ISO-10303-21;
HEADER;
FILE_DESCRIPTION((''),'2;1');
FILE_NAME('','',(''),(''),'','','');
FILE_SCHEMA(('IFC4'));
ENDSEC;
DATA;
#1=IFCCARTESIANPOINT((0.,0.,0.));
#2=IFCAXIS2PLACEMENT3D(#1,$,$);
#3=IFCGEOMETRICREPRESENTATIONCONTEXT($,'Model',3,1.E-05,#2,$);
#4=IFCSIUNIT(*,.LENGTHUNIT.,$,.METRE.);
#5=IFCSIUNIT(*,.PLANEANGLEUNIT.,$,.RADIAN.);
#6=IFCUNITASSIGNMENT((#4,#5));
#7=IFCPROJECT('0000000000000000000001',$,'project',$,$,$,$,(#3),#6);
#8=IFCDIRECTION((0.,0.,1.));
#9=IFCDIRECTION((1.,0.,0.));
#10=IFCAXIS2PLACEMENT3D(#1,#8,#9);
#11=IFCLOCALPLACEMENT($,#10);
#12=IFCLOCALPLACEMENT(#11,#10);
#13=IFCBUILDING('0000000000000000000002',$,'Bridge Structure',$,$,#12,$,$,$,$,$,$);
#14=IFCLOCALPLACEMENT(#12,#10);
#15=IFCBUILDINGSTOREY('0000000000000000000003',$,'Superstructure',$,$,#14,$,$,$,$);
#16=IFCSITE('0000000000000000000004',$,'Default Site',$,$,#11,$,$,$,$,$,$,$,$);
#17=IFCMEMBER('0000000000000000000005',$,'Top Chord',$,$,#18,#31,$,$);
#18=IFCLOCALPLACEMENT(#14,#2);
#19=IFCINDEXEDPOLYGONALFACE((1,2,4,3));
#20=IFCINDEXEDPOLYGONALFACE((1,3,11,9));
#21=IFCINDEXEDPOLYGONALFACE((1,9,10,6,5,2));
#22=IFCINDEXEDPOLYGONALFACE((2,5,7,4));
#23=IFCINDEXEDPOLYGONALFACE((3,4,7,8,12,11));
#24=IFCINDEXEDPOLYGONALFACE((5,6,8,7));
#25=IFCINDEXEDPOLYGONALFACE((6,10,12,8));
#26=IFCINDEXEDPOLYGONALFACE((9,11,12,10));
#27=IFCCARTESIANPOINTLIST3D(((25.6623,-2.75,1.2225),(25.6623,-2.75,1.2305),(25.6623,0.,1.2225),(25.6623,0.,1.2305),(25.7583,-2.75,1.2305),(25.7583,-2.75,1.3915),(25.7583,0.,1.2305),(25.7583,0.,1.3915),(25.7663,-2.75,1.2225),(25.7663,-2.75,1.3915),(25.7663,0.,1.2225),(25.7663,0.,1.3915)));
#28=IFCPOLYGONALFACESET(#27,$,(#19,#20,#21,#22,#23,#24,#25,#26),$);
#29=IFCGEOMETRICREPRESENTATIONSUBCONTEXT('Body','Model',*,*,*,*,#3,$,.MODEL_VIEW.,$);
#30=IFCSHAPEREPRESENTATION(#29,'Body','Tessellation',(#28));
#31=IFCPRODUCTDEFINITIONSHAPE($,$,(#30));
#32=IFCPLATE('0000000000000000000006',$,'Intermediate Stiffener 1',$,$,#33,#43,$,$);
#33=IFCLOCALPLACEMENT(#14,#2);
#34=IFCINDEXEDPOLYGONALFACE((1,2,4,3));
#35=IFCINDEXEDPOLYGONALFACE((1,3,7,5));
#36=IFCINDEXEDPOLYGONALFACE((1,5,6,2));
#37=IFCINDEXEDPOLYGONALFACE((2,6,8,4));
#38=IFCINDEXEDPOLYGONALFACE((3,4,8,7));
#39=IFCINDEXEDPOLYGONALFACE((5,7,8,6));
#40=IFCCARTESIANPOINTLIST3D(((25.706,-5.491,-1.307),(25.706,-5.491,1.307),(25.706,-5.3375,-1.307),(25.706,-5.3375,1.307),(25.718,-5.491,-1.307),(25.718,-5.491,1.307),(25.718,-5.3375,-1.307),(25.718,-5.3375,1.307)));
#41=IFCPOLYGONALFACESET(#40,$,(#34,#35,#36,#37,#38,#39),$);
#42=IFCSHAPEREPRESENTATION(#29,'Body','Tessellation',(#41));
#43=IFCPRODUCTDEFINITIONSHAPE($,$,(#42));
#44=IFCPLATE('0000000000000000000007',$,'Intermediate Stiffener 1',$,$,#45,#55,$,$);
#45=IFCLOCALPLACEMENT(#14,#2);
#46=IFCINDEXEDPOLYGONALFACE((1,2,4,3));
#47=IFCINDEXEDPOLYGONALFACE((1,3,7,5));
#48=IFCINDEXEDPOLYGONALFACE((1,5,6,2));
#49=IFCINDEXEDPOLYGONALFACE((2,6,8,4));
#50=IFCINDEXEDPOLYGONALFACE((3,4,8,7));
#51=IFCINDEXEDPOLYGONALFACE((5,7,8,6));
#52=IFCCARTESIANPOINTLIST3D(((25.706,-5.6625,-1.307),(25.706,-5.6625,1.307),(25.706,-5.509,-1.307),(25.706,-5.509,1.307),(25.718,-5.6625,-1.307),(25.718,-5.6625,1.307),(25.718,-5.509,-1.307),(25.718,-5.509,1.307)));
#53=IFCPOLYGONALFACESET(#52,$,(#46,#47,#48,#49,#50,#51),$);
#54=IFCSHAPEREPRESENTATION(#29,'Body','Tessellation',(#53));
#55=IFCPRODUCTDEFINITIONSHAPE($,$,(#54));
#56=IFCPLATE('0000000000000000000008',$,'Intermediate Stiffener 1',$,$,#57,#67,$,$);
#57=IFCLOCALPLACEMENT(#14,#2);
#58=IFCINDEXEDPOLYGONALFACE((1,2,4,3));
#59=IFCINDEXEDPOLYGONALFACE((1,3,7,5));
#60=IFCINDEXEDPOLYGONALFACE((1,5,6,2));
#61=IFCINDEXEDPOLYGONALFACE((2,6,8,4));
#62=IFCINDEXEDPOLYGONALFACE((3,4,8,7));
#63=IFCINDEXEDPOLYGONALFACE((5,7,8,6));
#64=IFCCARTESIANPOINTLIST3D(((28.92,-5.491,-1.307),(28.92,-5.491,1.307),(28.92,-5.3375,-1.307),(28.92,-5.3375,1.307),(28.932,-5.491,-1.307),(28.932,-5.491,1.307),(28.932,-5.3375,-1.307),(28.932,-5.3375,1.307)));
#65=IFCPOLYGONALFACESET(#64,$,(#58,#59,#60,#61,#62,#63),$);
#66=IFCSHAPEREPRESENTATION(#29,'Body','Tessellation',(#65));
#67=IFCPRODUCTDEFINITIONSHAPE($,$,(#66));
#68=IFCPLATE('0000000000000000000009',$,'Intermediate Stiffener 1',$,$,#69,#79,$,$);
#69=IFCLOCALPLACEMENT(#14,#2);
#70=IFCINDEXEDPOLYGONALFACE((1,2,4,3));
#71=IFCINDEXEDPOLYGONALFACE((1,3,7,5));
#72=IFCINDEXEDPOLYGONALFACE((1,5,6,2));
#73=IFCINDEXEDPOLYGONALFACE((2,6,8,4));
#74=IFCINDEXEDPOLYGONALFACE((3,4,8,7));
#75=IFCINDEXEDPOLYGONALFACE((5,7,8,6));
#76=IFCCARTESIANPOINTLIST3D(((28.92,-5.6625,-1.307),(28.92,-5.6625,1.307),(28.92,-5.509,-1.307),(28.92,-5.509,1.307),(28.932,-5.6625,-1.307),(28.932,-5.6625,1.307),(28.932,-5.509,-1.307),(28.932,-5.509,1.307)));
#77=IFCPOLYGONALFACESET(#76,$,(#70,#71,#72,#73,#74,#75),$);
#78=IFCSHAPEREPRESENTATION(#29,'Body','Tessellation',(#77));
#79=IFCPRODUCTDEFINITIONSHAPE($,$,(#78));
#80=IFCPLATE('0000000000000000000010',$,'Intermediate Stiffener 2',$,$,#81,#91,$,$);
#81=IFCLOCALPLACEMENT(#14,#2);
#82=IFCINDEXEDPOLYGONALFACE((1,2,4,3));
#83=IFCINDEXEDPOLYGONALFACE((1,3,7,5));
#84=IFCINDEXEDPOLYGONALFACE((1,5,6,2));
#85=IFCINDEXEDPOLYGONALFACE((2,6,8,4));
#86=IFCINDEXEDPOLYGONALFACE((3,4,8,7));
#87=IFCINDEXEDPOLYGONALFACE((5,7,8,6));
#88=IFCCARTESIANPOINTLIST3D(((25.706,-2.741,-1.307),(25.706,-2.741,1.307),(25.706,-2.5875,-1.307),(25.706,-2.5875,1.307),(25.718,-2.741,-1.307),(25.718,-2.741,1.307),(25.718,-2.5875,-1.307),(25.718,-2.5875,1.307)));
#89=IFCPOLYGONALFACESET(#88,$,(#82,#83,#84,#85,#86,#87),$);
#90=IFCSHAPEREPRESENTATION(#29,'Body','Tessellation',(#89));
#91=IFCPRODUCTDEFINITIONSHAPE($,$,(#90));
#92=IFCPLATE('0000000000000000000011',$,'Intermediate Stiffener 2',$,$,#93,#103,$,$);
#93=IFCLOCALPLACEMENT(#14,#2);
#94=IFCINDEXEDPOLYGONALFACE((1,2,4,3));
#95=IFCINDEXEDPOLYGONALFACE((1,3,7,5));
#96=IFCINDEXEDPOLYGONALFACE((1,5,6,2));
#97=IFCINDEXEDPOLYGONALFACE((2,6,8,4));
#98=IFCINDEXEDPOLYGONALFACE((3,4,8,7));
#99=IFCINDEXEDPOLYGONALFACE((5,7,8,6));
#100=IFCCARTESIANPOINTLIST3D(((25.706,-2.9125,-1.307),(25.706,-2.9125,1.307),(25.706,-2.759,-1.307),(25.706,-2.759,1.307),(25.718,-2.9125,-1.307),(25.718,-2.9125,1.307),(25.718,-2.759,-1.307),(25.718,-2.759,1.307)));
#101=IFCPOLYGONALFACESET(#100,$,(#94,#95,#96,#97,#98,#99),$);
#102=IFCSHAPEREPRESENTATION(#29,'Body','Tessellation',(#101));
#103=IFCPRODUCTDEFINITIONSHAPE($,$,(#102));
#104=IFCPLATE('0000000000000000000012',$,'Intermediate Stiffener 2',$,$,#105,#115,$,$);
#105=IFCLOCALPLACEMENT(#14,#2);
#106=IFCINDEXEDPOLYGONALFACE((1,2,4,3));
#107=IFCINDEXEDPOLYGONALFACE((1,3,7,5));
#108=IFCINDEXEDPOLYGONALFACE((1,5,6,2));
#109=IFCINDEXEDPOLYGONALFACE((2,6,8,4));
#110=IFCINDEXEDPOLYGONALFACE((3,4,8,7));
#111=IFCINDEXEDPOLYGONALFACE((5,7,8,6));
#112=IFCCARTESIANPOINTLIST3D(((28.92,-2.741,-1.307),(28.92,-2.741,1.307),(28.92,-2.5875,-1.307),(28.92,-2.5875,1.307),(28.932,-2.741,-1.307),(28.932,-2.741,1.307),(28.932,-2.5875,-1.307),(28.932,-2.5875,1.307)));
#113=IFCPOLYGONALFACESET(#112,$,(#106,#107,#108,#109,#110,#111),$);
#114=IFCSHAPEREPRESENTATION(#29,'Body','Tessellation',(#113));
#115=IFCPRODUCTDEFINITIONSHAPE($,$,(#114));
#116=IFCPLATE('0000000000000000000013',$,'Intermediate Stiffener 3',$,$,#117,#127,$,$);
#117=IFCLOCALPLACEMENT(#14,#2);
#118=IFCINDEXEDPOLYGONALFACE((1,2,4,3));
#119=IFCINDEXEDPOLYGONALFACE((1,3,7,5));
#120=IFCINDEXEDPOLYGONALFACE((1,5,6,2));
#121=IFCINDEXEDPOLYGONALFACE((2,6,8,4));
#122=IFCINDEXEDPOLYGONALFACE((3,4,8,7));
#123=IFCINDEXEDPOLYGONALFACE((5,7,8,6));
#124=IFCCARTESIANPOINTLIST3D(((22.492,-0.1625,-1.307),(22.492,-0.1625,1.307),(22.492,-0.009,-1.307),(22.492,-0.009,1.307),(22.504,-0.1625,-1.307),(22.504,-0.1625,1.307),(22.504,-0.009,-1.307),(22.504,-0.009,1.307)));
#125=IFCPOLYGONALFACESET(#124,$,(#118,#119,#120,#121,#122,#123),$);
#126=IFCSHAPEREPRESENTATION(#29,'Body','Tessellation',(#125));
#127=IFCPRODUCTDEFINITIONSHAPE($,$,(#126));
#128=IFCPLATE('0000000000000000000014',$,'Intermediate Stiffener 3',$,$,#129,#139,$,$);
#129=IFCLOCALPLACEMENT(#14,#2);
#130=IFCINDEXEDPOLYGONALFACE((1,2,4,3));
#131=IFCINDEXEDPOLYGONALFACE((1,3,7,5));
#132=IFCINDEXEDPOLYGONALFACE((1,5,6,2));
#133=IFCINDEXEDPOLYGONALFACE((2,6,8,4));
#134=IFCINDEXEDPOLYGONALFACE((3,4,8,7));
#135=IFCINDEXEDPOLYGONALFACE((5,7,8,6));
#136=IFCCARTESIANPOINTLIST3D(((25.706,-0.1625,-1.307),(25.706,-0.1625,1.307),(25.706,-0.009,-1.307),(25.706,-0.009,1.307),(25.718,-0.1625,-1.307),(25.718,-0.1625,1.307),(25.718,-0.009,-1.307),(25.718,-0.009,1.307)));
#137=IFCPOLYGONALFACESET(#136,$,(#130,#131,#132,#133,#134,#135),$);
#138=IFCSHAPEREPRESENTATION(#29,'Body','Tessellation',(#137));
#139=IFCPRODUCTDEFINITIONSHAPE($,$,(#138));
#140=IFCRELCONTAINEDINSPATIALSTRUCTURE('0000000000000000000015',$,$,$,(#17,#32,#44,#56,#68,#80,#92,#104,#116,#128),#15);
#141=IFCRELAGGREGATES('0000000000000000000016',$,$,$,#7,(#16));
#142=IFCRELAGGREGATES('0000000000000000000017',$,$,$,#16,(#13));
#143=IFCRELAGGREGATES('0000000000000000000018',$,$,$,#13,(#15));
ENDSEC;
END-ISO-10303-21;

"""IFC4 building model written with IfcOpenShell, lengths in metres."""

from ifc_helpers import new_model, si_unit, frame, origin, origin_with_axes, origin_2d_with_axis, place, context, subcontext, project, spatial, rectangle, l_section, extrude, element, save


model = new_model("IFC4")

# Units and contexts
model_context = context("Model", 3, precision=1e-05, world=origin())
body_context = subcontext(model_context, "Body", "Model", "MODEL_VIEW")
ifc_project = project(units=[si_unit("LENGTHUNIT", "METRE"), si_unit("PLANEANGLEUNIT", "RADIAN")], contexts=[model_context])

# Site, building, storey
site_placement = place(None, origin_with_axes())
site = spatial("IfcSite", under=ifc_project, at=site_placement, Name="Default Site")
building_placement = place(site_placement, origin_with_axes())
building = spatial("IfcBuilding", under=site, at=building_placement, Name="Bridge Structure")
storey_placement = place(building_placement, origin_with_axes())
storey = spatial("IfcBuildingStorey", under=building, at=storey_placement, Name="Superstructure")

# Member
for number, where, z_axis, x_axis, name in (
    (1, (25.7143, -2.75, 1.307), (0.0, 1.0, 0.0), (-1.0, 0.0, 0.0), "Top Chord"),
):
    element("IfcMember", number, at=place(storey_placement, frame(where, z_axis=z_axis, x_axis=x_axis)), inside=storey, Name=name, context=body_context, shape_type="SweptSolid", body=[
        extrude(l_section(Depth=0.169, Width=0.104, Thickness=0.008, at=origin_2d_with_axis()), origin_with_axes(), (0.0, 0.0, 1.0), 2.75),
    ])

# Plates
for number, where, z_axis, x_axis, name in (
    (2, (25.712, -5.4143, -1.307), (0.0, 0.0, 1.0), (1.0, 0.0, 0.0), "Intermediate Stiffener 1"),
    (3, (25.712, -5.5857, -1.307), (0.0, 0.0, 1.0), (1.0, 0.0, 0.0), "Intermediate Stiffener 1"),
    (4, (28.926, -5.4143, -1.307), (0.0, 0.0, 1.0), (1.0, 0.0, 0.0), "Intermediate Stiffener 1"),
    (5, (28.926, -5.5857, -1.307), (0.0, 0.0, 1.0), (1.0, 0.0, 0.0), "Intermediate Stiffener 1"),
    (6, (25.712, -2.6643, -1.307), (0.0, 0.0, 1.0), (1.0, 0.0, 0.0), "Intermediate Stiffener 2"),
    (7, (25.712, -2.8357, -1.307), (0.0, 0.0, 1.0), (1.0, 0.0, 0.0), "Intermediate Stiffener 2"),
    (8, (28.926, -2.6643, -1.307), (0.0, 0.0, 1.0), (1.0, 0.0, 0.0), "Intermediate Stiffener 2"),
    (9, (22.498, -0.0858, -1.307), (0.0, 0.0, 1.0), (1.0, 0.0, 0.0), "Intermediate Stiffener 3"),
    (10, (25.712, -0.0858, -1.307), (0.0, 0.0, 1.0), (1.0, 0.0, 0.0), "Intermediate Stiffener 3"),
):
    element("IfcPlate", number, at=place(storey_placement, frame(where, z_axis=z_axis, x_axis=x_axis)), inside=storey, Name=name, context=body_context, shape_type="SweptSolid", body=[
        extrude(rectangle(XDim=0.012, YDim=0.1535, at=origin_2d_with_axis()), origin_with_axes(), (0.0, 0.0, 1.0), 2.614),
    ])

save(model, "model.ifc")
